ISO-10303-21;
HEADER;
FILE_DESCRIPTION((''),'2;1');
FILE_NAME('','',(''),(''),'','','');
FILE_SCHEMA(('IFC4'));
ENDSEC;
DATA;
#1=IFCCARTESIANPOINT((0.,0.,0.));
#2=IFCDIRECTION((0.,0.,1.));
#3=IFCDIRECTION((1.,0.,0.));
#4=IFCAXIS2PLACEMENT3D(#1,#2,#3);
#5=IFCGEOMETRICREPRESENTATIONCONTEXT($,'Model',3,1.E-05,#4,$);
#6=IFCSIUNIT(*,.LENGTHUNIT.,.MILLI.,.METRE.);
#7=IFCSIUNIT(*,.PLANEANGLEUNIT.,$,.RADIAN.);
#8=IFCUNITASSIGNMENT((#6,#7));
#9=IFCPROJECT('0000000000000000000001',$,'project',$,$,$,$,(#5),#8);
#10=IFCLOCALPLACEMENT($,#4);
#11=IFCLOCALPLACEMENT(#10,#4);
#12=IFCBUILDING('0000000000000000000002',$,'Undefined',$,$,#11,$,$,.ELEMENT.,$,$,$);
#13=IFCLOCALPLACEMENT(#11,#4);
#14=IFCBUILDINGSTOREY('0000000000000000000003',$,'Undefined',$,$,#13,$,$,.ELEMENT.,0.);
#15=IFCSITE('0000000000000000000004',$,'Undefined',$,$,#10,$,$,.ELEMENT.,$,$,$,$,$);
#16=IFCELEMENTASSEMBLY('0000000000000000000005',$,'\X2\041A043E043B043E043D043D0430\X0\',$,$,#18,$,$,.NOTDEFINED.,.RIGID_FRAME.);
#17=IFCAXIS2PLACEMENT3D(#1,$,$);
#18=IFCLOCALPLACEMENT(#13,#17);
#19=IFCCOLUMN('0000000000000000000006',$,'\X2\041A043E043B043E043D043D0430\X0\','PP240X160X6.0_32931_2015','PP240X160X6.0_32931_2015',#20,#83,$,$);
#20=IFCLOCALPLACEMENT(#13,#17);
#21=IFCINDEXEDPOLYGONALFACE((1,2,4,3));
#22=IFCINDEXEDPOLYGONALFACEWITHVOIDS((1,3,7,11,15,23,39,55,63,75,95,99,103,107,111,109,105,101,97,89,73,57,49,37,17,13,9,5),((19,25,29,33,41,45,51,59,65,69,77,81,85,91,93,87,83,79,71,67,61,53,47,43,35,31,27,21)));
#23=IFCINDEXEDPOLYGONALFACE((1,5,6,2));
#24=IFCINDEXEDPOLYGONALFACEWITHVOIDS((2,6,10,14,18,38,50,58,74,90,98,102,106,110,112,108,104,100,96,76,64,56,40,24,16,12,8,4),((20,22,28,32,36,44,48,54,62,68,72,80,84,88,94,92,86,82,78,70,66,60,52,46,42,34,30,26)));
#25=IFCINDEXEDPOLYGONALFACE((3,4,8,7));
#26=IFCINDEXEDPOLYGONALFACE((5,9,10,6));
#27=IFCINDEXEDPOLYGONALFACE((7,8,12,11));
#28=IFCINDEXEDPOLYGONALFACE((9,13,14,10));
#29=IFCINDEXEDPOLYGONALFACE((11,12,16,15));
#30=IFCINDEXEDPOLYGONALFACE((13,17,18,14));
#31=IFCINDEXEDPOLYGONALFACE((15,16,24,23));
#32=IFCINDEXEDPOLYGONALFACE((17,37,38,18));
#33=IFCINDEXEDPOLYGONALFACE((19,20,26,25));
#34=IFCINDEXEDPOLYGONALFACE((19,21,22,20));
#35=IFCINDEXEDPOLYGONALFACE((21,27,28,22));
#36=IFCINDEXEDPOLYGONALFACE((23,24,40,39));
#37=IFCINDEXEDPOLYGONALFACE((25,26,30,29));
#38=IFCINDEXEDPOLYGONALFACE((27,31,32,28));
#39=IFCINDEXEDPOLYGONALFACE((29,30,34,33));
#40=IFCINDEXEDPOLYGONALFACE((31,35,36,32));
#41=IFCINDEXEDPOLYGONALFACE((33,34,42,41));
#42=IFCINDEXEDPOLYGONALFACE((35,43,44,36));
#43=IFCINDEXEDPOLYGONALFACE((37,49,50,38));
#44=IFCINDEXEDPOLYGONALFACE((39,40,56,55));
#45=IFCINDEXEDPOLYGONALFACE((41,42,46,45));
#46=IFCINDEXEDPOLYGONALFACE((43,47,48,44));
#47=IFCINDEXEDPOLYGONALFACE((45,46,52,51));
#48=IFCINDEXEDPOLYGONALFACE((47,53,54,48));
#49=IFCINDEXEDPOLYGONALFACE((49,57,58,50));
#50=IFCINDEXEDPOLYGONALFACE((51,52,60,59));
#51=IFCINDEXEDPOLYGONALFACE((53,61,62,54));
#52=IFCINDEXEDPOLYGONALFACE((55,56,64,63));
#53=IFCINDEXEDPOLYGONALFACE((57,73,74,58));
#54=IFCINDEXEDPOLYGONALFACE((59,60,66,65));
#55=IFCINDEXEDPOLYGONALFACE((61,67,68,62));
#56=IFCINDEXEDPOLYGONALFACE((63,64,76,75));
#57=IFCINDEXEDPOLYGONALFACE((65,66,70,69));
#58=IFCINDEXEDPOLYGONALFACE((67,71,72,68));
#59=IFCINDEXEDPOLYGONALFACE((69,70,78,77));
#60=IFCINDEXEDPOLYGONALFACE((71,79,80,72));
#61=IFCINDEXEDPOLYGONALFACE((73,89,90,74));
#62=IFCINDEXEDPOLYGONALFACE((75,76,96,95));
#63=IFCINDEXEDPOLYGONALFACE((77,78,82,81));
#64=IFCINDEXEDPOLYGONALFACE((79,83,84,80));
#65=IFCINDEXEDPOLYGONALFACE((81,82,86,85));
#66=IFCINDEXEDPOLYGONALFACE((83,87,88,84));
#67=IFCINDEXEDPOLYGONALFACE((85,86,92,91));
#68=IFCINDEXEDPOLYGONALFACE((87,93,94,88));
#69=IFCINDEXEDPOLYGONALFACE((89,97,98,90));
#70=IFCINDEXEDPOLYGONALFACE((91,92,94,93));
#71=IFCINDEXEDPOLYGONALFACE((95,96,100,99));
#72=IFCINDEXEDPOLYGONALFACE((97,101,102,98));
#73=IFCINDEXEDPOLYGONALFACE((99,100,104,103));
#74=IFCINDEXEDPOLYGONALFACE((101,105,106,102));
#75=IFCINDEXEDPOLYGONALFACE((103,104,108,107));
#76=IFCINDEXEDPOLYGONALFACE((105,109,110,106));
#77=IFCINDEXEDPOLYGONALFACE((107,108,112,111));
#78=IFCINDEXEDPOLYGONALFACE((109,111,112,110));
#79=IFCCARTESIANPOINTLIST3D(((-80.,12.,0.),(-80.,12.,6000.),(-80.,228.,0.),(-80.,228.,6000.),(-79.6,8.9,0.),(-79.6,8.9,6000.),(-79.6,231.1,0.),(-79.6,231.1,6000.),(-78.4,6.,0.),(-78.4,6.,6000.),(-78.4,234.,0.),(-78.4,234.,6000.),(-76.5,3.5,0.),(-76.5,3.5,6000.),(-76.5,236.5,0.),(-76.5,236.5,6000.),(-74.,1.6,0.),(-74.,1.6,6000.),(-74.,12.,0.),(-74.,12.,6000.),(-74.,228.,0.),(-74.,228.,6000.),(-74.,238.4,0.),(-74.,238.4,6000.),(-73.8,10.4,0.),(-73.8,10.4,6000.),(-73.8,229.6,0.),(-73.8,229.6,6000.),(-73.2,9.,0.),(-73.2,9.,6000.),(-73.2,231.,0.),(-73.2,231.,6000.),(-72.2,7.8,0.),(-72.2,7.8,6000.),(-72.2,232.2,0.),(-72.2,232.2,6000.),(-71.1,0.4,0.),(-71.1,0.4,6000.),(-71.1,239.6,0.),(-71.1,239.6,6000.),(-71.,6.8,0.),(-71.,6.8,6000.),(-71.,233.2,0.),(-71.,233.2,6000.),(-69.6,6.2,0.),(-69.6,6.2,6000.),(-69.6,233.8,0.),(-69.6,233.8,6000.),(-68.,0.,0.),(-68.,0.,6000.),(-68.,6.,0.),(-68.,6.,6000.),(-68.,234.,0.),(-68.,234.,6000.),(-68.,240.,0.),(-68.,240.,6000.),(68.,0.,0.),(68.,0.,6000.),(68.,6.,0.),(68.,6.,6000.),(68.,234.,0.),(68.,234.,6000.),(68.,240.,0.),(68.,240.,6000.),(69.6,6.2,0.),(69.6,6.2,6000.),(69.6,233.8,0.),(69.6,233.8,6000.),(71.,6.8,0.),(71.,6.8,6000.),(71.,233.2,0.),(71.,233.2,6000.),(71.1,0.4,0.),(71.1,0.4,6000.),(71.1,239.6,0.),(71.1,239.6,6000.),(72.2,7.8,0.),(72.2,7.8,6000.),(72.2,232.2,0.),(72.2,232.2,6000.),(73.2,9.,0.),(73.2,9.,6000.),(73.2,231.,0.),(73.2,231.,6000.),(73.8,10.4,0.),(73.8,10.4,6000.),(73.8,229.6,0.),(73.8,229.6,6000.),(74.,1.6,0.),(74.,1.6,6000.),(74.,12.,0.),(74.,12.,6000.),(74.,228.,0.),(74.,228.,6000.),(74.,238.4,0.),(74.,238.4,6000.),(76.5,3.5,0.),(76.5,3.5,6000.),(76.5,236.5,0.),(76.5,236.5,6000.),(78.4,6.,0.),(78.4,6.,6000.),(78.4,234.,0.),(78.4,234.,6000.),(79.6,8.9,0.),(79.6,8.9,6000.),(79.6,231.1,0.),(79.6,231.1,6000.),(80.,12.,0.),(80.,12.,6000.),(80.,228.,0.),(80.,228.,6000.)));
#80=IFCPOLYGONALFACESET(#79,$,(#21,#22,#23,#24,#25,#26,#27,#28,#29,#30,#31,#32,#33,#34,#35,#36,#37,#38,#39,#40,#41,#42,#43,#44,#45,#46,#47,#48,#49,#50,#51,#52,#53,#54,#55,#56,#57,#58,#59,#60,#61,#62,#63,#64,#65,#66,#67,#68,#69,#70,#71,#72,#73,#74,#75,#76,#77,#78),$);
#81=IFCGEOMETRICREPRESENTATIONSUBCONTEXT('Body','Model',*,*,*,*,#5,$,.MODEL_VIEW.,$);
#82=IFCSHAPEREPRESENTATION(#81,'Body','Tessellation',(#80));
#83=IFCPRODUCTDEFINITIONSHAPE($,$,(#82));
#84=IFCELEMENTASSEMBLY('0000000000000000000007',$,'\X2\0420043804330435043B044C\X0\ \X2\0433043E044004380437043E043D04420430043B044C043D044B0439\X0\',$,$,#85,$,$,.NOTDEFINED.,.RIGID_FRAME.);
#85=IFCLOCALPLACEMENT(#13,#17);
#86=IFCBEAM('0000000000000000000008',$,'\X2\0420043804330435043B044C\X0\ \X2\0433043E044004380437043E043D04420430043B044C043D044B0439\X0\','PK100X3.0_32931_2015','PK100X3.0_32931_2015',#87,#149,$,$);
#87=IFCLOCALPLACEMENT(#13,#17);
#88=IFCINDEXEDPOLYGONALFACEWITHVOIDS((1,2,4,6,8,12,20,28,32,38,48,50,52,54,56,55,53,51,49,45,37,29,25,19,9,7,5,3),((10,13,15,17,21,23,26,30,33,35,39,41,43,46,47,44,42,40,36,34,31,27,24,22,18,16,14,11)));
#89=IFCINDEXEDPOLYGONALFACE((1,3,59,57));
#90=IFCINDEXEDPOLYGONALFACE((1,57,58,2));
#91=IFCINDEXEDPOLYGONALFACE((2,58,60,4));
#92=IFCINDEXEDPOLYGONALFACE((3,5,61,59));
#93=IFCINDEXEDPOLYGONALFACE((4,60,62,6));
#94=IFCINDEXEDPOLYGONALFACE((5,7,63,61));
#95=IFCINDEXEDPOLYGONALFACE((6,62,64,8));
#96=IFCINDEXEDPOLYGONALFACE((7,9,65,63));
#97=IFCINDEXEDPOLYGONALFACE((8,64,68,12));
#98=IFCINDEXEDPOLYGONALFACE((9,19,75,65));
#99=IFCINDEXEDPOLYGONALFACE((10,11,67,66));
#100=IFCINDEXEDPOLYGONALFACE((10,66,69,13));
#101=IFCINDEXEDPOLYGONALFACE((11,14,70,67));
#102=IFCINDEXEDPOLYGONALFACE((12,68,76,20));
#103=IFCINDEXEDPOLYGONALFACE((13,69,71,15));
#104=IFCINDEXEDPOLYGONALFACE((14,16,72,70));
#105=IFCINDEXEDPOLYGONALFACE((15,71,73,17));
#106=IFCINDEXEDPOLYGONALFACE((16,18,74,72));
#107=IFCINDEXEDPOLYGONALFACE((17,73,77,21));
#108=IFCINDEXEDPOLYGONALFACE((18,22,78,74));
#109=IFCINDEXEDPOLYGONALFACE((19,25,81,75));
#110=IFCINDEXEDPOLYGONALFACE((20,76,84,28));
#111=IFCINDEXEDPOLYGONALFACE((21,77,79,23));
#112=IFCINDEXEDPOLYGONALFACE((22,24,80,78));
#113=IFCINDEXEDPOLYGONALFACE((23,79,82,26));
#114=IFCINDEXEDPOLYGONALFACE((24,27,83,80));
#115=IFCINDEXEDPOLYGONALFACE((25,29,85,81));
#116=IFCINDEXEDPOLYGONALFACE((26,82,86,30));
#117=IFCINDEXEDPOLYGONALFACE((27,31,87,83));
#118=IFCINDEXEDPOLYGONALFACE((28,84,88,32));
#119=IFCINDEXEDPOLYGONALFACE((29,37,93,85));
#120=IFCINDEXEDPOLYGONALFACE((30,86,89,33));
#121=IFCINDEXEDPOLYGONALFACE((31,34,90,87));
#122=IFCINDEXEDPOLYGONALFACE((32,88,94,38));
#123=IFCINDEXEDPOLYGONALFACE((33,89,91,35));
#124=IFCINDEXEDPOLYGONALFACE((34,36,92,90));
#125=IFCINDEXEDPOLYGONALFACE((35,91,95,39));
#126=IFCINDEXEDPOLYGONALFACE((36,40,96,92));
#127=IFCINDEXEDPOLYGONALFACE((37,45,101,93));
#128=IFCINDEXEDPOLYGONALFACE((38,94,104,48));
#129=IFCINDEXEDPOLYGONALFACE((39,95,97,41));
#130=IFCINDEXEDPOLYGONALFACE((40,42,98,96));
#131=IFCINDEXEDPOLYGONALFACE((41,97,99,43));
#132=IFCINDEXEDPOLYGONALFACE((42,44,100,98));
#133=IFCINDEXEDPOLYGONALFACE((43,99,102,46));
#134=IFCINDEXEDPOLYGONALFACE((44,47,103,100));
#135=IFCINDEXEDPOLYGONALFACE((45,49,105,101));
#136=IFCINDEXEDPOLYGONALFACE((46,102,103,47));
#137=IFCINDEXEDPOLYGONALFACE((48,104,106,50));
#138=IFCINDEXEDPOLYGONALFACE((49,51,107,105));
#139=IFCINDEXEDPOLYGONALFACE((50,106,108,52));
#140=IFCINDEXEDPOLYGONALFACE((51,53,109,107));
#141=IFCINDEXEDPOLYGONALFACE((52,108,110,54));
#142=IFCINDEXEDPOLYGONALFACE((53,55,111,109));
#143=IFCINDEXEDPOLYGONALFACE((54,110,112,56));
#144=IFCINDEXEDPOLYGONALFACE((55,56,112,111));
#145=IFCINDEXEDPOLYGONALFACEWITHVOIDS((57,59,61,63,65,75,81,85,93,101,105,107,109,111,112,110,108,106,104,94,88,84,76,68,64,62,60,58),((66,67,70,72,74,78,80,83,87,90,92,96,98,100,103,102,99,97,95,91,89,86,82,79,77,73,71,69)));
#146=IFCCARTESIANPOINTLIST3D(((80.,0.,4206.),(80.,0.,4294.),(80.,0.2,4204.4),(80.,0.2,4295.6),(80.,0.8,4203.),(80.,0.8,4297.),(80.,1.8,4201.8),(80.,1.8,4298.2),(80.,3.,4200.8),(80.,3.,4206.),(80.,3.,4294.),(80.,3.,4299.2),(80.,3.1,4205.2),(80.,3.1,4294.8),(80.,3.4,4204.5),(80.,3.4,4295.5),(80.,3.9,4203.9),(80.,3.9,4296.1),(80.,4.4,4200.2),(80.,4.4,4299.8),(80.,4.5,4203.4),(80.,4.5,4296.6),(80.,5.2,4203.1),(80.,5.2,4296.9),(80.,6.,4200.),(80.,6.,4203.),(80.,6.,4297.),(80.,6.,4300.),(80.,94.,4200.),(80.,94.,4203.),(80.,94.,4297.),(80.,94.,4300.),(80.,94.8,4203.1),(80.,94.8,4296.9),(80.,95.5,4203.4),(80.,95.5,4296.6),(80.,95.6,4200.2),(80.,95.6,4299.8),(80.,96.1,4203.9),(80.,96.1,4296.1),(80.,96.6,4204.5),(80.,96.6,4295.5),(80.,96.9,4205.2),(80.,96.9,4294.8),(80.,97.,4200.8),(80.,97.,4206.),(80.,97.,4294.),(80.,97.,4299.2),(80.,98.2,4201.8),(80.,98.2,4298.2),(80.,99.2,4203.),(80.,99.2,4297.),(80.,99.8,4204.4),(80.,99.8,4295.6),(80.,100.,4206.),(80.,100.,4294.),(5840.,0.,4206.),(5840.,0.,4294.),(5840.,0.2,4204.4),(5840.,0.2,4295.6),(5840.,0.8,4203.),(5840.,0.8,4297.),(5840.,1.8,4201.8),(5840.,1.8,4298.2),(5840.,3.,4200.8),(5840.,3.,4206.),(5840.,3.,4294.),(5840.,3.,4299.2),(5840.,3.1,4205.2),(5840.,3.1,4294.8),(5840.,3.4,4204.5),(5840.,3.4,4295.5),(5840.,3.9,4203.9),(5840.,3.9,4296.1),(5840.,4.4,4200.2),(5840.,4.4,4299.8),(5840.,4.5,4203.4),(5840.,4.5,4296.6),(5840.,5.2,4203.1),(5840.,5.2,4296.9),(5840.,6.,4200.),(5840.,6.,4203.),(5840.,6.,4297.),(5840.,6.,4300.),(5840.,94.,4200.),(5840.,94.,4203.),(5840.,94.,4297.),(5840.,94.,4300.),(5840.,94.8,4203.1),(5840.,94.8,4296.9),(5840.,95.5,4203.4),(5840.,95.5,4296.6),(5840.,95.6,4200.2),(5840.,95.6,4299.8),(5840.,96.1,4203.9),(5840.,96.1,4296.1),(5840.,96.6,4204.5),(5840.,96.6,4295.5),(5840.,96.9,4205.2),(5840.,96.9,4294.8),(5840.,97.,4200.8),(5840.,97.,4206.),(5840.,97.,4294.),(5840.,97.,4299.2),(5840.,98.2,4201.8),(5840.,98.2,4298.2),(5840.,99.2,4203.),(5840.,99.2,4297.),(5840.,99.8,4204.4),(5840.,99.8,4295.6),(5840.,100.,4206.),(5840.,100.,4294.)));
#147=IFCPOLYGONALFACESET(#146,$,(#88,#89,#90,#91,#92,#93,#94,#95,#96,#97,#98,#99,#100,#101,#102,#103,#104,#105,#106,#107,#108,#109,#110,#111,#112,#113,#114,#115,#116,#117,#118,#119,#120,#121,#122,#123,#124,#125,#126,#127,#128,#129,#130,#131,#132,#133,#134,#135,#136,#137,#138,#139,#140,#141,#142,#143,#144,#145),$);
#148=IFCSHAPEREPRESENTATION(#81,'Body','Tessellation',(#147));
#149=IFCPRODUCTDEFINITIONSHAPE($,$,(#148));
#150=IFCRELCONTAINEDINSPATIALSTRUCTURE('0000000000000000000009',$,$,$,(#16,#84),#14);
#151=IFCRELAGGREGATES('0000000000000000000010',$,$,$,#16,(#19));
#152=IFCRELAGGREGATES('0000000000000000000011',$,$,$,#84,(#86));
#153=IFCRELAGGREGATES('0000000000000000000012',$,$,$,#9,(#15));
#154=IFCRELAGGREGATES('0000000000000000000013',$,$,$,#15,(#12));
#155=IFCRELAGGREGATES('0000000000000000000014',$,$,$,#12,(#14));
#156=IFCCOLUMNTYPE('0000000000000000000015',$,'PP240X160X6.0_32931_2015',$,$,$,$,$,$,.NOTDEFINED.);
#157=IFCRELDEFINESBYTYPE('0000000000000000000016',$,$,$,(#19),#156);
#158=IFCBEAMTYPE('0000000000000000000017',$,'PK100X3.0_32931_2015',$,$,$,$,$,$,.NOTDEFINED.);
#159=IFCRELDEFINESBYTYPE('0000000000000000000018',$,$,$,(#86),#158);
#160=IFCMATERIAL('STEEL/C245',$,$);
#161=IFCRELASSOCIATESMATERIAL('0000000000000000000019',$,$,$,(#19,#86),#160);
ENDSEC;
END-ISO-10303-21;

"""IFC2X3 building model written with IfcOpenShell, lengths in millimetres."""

from ifc_helpers import new_model, si_unit, frame, origin_with_axes, origin_2d_with_axis, place, context, subcontext, project, spatial, hollow_rectangle, extrude, material, type_object, element, aggregate, save


model = new_model("IFC2X3")

# Units and contexts
model_context = context("Model", 3, precision=1e-05, world=origin_with_axes())
body_context = subcontext(model_context, "Body", "Model", "MODEL_VIEW")
ifc_project = project(units=[si_unit("LENGTHUNIT", "METRE", prefix="MILLI"), si_unit("PLANEANGLEUNIT", "RADIAN")], contexts=[model_context])

# Site, building, storey
site_placement = place(None, origin_with_axes())
site = spatial("IfcSite", under=ifc_project, at=site_placement, Name="Undefined", CompositionType="ELEMENT")
building_placement = place(site_placement, origin_with_axes())
building = spatial("IfcBuilding", under=site, at=building_placement, Name="Undefined", CompositionType="ELEMENT")
storey_placement = place(building_placement, origin_with_axes())
storey = spatial("IfcBuildingStorey", under=building, at=storey_placement, Name="Undefined", CompositionType="ELEMENT", Elevation=0.0)

# Element assembly, column
ifc_material = material(Name="STEEL/C245")
column_type_1 = type_object("IfcColumnType", Name="PP240X160X6.0_32931_2015", PredefinedType="NOTDEFINED")
assembly_1_placement = place(storey_placement, origin_with_axes())
assembly_1 = element("IfcElementAssembly", 1, at=assembly_1_placement, inside=storey, Name="Колонна", AssemblyPlace="NOTDEFINED", PredefinedType="RIGID_FRAME")
column_1_placement = place(assembly_1_placement, frame((0.0, 120.0, 0.0), z_axis=(0.0, 0.0, 1.0), x_axis=(0.0, 1.0, 0.0)))
column_1 = element("IfcColumn", 2, at=column_1_placement, type_object=column_type_1, material=ifc_material, Name="Колонна", Description="PP240X160X6.0_32931_2015", ObjectType="PP240X160X6.0_32931_2015", context=body_context, shape_type="SweptSolid", body=[
    extrude(hollow_rectangle(XDim=160.0, YDim=240.0, WallThickness=6.0, InnerFilletRadius=6.0, OuterFilletRadius=12.0, at=origin_2d_with_axis()), frame((0.0, 0.0, 6000.0), z_axis=(0.0, 0.0, -1.0), x_axis=(0.0, 1.0, 0.0)), (0.0, 0.0, 1.0), 6000.0),
])
aggregate(assembly_1, [column_1])

# Element assembly, beam
assembly_2_placement = place(storey_placement, origin_with_axes())
assembly_2 = element("IfcElementAssembly", 3, at=assembly_2_placement, inside=storey, Name="Ригель горизонтальный", AssemblyPlace="NOTDEFINED", PredefinedType="RIGID_FRAME")
beam_type_1 = type_object("IfcBeamType", Name="PK100X3.0_32931_2015", PredefinedType="NOTDEFINED")
beam_1_placement = place(assembly_2_placement, frame((80.0, 50.0, 4250.0), z_axis=(0.0, 0.0, 1.0), x_axis=(1.0, 0.0, 0.0)))
beam_1 = element("IfcBeam", 4, at=beam_1_placement, type_object=beam_type_1, material=ifc_material, Name="Ригель горизонтальный", Description="PK100X3.0_32931_2015", ObjectType="PK100X3.0_32931_2015", context=body_context, shape_type="SweptSolid", body=[
    extrude(hollow_rectangle(XDim=100.0, YDim=100.0, WallThickness=3.0, InnerFilletRadius=3.0, OuterFilletRadius=6.0, at=origin_2d_with_axis()), frame((5760.0, 0.0, 0.0), z_axis=(-1.0, 0.0, 0.0), x_axis=(0.0, -1.0, 0.0)), (0.0, 0.0, 1.0), 5760.0),
])
aggregate(assembly_2, [beam_1])

save(model, "model.ifc")
